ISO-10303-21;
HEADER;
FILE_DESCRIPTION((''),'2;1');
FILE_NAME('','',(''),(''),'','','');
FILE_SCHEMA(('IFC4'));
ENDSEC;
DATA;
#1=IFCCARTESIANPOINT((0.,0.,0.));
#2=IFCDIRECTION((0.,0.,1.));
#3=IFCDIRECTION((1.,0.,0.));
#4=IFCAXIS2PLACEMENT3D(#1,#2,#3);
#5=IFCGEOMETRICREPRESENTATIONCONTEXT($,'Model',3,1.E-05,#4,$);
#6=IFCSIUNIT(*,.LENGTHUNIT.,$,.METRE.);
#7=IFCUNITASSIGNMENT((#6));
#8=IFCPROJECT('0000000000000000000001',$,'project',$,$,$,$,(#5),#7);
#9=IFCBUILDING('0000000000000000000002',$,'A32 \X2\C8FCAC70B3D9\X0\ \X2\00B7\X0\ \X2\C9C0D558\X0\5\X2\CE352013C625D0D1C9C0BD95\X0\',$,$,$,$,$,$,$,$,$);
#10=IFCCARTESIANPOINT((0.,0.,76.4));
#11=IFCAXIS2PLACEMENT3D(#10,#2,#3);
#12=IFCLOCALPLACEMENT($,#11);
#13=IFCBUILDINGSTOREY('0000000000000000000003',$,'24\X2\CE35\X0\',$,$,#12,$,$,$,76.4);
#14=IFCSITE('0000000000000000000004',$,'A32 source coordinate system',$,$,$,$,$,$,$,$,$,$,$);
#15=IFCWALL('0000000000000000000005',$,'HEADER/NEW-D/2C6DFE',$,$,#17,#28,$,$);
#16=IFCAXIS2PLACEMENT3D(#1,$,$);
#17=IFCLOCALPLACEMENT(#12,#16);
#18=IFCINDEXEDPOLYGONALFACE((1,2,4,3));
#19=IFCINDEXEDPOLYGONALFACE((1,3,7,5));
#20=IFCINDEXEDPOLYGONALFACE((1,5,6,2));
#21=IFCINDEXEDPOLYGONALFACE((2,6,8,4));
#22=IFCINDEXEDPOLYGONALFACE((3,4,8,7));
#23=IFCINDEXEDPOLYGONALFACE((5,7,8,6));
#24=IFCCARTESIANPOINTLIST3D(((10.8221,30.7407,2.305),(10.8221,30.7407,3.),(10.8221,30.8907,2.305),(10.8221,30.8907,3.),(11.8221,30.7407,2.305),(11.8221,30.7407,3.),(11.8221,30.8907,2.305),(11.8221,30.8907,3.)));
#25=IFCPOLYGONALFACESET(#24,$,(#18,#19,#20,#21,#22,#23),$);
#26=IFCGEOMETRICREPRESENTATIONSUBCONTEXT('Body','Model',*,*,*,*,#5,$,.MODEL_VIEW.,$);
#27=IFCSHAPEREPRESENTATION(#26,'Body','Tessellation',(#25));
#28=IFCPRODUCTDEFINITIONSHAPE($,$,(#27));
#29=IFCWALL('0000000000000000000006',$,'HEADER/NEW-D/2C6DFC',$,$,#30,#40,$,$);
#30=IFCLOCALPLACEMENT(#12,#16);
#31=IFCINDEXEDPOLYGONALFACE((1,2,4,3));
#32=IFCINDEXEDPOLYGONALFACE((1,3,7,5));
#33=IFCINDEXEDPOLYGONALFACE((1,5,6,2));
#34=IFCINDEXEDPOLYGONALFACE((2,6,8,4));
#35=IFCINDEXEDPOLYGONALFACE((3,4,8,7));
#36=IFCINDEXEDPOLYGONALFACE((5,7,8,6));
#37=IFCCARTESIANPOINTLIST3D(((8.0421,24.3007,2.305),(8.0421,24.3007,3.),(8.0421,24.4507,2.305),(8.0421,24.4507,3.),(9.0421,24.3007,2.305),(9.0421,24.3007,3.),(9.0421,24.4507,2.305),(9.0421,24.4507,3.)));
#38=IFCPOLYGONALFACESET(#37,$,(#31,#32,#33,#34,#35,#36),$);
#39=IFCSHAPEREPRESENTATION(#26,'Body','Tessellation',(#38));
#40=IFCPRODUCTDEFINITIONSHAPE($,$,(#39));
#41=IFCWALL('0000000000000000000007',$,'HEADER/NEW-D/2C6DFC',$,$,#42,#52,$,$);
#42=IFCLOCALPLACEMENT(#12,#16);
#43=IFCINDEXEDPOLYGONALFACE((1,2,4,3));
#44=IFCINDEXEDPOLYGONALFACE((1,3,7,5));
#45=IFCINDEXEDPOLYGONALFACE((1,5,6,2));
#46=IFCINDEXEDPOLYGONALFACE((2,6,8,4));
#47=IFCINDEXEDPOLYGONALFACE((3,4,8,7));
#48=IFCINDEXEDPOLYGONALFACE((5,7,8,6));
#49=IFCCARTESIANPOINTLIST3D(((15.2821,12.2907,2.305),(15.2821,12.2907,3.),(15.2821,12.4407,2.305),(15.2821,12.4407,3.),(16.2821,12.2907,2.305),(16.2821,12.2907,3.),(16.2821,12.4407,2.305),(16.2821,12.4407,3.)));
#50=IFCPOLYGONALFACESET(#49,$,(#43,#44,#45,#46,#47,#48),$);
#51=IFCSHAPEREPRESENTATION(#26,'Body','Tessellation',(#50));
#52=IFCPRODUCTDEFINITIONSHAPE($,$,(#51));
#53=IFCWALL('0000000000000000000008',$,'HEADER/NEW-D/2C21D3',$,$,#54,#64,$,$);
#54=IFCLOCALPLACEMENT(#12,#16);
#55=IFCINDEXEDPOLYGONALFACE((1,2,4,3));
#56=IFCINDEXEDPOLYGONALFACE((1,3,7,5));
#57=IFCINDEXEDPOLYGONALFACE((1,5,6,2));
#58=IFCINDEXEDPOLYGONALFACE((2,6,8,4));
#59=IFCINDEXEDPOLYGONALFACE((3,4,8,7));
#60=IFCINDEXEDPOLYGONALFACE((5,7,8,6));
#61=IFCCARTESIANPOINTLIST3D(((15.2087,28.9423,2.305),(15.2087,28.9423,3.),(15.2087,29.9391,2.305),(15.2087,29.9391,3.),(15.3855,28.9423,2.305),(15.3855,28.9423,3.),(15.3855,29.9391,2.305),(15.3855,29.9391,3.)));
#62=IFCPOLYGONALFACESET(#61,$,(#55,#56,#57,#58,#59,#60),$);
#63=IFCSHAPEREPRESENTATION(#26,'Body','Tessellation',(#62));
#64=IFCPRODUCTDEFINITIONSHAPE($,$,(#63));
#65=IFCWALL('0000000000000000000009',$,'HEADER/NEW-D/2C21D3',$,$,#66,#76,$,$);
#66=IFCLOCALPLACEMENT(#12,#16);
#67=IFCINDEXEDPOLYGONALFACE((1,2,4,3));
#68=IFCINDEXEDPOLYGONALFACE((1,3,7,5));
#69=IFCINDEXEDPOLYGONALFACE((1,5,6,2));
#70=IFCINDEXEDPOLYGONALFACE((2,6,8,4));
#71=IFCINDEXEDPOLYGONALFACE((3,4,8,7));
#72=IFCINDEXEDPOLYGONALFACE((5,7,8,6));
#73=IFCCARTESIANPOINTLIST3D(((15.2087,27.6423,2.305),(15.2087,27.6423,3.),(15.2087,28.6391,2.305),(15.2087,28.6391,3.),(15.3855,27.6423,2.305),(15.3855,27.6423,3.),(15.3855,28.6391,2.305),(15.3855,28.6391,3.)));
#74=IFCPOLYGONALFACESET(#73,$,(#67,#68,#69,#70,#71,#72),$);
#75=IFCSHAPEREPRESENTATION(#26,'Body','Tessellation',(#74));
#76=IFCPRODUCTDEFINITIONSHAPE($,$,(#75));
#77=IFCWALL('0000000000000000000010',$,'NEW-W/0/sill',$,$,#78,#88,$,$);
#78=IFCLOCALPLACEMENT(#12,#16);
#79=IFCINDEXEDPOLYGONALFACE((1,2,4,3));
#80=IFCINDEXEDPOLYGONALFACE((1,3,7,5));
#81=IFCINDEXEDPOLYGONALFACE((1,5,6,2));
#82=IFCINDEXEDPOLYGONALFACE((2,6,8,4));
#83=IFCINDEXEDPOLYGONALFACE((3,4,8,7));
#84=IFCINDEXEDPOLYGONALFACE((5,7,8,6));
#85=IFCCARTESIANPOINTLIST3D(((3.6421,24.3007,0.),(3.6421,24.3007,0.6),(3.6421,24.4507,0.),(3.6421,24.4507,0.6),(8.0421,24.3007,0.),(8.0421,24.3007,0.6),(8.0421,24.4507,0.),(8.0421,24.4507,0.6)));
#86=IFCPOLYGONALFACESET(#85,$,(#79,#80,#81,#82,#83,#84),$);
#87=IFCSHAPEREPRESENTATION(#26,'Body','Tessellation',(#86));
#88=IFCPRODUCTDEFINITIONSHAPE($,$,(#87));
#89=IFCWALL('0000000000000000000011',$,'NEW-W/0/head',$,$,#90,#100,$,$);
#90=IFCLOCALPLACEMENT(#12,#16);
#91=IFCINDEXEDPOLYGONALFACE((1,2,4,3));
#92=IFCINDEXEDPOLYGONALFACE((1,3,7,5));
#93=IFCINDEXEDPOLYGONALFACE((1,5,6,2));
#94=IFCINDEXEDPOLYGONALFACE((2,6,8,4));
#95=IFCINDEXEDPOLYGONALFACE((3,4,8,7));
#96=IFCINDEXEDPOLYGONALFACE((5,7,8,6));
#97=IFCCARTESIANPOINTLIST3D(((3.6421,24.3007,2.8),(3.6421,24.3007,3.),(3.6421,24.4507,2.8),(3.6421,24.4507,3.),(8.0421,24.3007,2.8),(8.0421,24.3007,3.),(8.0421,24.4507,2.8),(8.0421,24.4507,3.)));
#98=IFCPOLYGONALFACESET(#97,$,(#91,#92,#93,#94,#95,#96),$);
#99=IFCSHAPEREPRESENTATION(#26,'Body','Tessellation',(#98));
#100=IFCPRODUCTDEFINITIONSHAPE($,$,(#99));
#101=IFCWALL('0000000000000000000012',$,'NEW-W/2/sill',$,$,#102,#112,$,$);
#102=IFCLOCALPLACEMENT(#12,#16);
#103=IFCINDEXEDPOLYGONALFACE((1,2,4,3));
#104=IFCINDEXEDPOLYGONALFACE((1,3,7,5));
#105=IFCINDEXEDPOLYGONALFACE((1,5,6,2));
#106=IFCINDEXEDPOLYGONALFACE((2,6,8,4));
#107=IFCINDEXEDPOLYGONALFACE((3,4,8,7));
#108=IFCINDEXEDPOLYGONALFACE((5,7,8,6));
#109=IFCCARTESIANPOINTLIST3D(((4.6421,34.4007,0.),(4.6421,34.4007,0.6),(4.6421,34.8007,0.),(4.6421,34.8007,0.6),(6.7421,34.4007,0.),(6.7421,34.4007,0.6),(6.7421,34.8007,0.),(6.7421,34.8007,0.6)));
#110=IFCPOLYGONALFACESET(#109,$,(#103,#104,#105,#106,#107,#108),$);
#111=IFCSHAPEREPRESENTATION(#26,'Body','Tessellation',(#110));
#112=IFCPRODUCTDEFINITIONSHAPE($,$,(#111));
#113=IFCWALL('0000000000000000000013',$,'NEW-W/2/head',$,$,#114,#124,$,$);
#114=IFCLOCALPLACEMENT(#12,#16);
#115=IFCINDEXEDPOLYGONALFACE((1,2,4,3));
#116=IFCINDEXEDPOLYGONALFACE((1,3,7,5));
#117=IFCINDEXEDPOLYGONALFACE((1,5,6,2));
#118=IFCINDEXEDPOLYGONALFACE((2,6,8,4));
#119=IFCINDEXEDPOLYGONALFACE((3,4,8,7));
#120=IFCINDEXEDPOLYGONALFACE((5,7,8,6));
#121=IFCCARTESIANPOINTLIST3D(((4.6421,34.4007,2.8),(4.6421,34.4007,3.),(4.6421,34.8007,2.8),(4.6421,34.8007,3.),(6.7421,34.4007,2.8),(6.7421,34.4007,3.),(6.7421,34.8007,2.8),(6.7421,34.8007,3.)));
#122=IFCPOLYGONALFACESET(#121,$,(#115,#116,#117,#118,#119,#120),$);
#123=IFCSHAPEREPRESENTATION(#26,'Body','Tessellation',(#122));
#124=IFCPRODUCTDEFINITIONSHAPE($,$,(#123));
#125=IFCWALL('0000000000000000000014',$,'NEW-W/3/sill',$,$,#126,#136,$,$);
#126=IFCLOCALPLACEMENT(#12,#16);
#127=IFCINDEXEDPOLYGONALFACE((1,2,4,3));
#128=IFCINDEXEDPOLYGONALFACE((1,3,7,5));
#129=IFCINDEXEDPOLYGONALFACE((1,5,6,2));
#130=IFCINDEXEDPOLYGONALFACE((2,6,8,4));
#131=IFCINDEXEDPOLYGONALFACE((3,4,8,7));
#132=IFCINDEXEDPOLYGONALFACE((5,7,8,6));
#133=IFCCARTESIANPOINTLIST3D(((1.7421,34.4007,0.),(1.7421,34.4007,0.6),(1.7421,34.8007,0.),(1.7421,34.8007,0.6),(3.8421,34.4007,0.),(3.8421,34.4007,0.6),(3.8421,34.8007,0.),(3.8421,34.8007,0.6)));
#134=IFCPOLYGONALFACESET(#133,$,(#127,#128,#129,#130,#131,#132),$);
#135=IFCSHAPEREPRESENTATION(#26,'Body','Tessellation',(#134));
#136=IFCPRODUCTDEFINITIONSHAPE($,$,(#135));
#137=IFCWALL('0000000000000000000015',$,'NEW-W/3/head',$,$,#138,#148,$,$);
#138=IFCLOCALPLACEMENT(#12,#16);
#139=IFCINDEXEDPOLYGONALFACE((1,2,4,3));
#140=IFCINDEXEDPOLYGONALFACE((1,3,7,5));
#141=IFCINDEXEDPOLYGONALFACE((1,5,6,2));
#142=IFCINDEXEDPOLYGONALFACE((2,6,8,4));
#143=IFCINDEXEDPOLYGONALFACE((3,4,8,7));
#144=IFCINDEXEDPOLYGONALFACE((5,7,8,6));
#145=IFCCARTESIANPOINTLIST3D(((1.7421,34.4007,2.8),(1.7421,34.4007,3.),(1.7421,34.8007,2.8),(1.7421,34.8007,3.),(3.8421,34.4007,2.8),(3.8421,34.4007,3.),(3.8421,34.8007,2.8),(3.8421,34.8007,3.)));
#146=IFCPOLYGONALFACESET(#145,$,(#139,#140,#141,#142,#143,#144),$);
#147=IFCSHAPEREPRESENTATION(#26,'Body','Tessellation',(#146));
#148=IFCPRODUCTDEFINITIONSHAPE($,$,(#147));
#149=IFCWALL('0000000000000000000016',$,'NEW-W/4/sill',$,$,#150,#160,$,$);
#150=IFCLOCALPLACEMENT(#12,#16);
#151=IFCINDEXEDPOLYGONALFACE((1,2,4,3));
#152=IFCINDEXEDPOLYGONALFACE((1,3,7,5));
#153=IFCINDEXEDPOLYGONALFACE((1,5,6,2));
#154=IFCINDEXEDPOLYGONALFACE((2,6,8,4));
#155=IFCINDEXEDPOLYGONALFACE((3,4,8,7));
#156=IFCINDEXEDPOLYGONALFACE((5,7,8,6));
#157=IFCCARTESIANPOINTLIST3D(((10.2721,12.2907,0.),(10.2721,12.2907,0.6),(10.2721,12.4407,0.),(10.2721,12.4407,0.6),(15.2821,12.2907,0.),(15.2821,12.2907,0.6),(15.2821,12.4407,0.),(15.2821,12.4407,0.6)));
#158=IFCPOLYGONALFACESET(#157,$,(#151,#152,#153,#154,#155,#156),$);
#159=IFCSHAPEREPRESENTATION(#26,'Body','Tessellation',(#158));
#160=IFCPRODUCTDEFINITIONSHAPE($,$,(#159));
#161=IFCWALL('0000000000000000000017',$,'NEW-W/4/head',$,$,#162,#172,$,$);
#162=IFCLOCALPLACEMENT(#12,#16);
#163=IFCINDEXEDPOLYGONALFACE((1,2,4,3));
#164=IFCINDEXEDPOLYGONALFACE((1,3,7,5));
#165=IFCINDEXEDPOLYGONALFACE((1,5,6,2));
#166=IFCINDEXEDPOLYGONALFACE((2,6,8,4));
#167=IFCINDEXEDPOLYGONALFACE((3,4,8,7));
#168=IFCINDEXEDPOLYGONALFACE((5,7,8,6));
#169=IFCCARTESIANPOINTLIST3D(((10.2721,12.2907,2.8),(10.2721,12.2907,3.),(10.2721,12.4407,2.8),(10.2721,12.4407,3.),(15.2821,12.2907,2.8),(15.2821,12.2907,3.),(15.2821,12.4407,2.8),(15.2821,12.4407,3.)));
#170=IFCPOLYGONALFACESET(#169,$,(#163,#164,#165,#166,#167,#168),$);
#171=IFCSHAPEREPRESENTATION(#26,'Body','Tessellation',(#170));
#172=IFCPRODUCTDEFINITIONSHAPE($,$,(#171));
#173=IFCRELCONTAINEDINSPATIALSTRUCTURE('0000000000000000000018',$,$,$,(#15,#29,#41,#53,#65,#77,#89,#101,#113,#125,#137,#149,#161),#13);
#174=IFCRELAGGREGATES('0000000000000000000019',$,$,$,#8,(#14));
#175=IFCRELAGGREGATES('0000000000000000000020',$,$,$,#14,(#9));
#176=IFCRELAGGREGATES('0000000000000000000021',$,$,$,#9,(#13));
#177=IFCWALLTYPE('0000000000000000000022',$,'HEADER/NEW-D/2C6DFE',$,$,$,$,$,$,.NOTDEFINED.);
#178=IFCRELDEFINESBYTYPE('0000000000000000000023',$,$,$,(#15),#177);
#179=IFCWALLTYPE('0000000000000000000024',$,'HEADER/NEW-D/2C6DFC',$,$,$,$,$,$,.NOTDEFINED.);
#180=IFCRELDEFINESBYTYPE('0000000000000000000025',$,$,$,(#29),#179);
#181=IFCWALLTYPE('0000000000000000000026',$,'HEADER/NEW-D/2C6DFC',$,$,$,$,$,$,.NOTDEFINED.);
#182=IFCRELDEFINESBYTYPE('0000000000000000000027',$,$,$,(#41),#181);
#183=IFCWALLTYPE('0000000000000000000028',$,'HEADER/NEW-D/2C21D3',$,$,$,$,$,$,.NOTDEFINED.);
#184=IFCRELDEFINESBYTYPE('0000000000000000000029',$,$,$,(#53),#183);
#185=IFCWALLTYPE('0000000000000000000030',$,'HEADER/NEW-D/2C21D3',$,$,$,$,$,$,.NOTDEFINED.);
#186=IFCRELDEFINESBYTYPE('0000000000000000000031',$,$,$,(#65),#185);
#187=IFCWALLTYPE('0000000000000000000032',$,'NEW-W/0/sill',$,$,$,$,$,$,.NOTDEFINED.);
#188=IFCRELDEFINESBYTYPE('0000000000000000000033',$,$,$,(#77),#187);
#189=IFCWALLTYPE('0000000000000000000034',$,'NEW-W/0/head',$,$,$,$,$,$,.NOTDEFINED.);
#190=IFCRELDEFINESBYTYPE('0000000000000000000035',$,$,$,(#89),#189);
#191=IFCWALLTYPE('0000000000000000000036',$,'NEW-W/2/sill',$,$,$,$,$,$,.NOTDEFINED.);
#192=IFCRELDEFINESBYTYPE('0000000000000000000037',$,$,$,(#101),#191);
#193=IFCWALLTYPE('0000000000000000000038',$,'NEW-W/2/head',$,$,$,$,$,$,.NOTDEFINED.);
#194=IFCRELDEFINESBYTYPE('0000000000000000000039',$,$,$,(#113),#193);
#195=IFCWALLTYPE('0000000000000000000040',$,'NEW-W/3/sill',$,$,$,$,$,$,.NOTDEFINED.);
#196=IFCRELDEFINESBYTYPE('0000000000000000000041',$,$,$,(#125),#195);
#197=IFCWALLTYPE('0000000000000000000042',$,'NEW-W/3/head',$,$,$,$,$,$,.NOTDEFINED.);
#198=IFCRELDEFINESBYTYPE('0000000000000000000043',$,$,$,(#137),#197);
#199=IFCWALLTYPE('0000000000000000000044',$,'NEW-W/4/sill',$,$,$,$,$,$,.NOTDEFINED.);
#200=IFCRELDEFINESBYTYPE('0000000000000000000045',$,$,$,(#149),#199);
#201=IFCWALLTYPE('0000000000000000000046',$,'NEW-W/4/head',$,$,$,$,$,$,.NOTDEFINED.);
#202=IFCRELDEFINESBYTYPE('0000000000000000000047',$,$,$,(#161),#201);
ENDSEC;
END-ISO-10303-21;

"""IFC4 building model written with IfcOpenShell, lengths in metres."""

from ifc_helpers import new_model, si_unit, frame, origin, origin_with_axes, place, context, subcontext, project, spatial, polyline, outline, extrude, source, transform, mapped, type_object, type_shapes, element, save


model = new_model("IFC4")

# Units and contexts
model_context = context("Model", 3, precision=1e-05, world=origin_with_axes())
body_context = subcontext(model_context, "Body", "Model", "MODEL_VIEW")
ifc_project = project(units=[si_unit("LENGTHUNIT", "METRE")], contexts=[model_context])

# Site, building, storey
site = spatial("IfcSite", under=ifc_project, Name="A32 source coordinate system")
building = spatial("IfcBuilding", under=site, Name="A32 주거동 · 지하5층–옥탑지붕")
storey_placement = place(None, frame((0.0, 0.0, 76.4), z_axis=(0.0, 0.0, 1.0), x_axis=(1.0, 0.0, 0.0)))
storey = spatial("IfcBuildingStorey", under=building, at=storey_placement, Name="24층", Elevation=76.4)

# Walls
wall_type_1 = type_object("IfcWallType", Name="HEADER/NEW-D/2C6DFE", PredefinedType="NOTDEFINED")
shared_shape_1 = source(origin(), body_context, "Body", "SweptSolid", [
    extrude(outline(polyline([(10.8221, 30.7407), (10.8221, 30.8907), (11.8221, 30.8907), (11.8221, 30.7407), (10.8221, 30.7407)])), frame((0.0, 0.0, 2.305)), (0.0, 0.0, 1.0), 0.695),
])
type_shapes(wall_type_1, [shared_shape_1])
wall_1_placement = place(storey_placement, origin_with_axes())
element("IfcWall", 1, at=wall_1_placement, inside=storey, type_object=wall_type_1, Name="HEADER/NEW-D/2C6DFE", context=body_context, shape_type="MappedRepresentation", body=[
    mapped(shared_shape_1, transform((0.0, 0.0, 0.0), scale=1.0)),
])
wall_type_2 = type_object("IfcWallType", Name="HEADER/NEW-D/2C6DFC", PredefinedType="NOTDEFINED")
shared_shape_2 = source(origin(), body_context, "Body", "SweptSolid", [
    extrude(outline(polyline([(8.0421, 24.3007), (8.0421, 24.4507), (9.0421, 24.4507), (9.0421, 24.3007), (8.0421, 24.3007)])), frame((0.0, 0.0, 2.305)), (0.0, 0.0, 1.0), 0.695),
])
type_shapes(wall_type_2, [shared_shape_2])
wall_2_placement = place(storey_placement, origin_with_axes())
element("IfcWall", 2, at=wall_2_placement, inside=storey, type_object=wall_type_2, Name="HEADER/NEW-D/2C6DFC", context=body_context, shape_type="MappedRepresentation", body=[
    mapped(shared_shape_2, transform((0.0, 0.0, 0.0), scale=1.0)),
])
wall_type_3 = type_object("IfcWallType", Name="HEADER/NEW-D/2C6DFC", PredefinedType="NOTDEFINED")
shared_shape_3 = source(origin(), body_context, "Body", "SweptSolid", [
    extrude(outline(polyline([(15.2821, 12.2907), (15.2821, 12.4407), (16.2821, 12.4407), (16.2821, 12.2907), (15.2821, 12.2907)])), frame((0.0, 0.0, 2.305)), (0.0, 0.0, 1.0), 0.695),
])
type_shapes(wall_type_3, [shared_shape_3])
wall_3_placement = place(storey_placement, origin_with_axes())
element("IfcWall", 3, at=wall_3_placement, inside=storey, type_object=wall_type_3, Name="HEADER/NEW-D/2C6DFC", context=body_context, shape_type="MappedRepresentation", body=[
    mapped(shared_shape_3, transform((0.0, 0.0, 0.0), scale=1.0)),
])
wall_type_4 = type_object("IfcWallType", Name="HEADER/NEW-D/2C21D3", PredefinedType="NOTDEFINED")
shared_shape_4 = source(origin(), body_context, "Body", "SweptSolid", [
    extrude(outline(polyline([(15.2087, 28.9423), (15.2087, 29.9391), (15.3855, 29.9391), (15.3855, 28.9423), (15.2087, 28.9423)])), frame((0.0, 0.0, 2.305)), (0.0, 0.0, 1.0), 0.695),
])
type_shapes(wall_type_4, [shared_shape_4])
wall_4_placement = place(storey_placement, origin_with_axes())
element("IfcWall", 4, at=wall_4_placement, inside=storey, type_object=wall_type_4, Name="HEADER/NEW-D/2C21D3", context=body_context, shape_type="MappedRepresentation", body=[
    mapped(shared_shape_4, transform((0.0, 0.0, 0.0), scale=1.0)),
])
wall_type_5 = type_object("IfcWallType", Name="HEADER/NEW-D/2C21D3", PredefinedType="NOTDEFINED")
shared_shape_5 = source(origin(), body_context, "Body", "SweptSolid", [
    extrude(outline(polyline([(15.2087, 27.6423), (15.2087, 28.6391), (15.3855, 28.6391), (15.3855, 27.6423), (15.2087, 27.6423)])), frame((0.0, 0.0, 2.305)), (0.0, 0.0, 1.0), 0.695),
])
type_shapes(wall_type_5, [shared_shape_5])
wall_5_placement = place(storey_placement, origin_with_axes())
element("IfcWall", 5, at=wall_5_placement, inside=storey, type_object=wall_type_5, Name="HEADER/NEW-D/2C21D3", context=body_context, shape_type="MappedRepresentation", body=[
    mapped(shared_shape_5, transform((0.0, 0.0, 0.0), scale=1.0)),
])
wall_type_6 = type_object("IfcWallType", Name="NEW-W/0/sill", PredefinedType="NOTDEFINED")
shared_shape_6 = source(origin(), body_context, "Body", "SweptSolid", [
    extrude(outline(polyline([(3.6421, 24.3007), (3.6421, 24.4507), (8.0421, 24.4507), (8.0421, 24.3007), (3.6421, 24.3007)])), origin(), (0.0, 0.0, 1.0), 0.6),
])
type_shapes(wall_type_6, [shared_shape_6])
wall_6_placement = place(storey_placement, origin_with_axes())
element("IfcWall", 6, at=wall_6_placement, inside=storey, type_object=wall_type_6, Name="NEW-W/0/sill", context=body_context, shape_type="MappedRepresentation", body=[
    mapped(shared_shape_6, transform((0.0, 0.0, 0.0), scale=1.0)),
])
wall_type_7 = type_object("IfcWallType", Name="NEW-W/0/head", PredefinedType="NOTDEFINED")
shared_shape_7 = source(origin(), body_context, "Body", "SweptSolid", [
    extrude(outline(polyline([(3.6421, 24.3007), (3.6421, 24.4507), (8.0421, 24.4507), (8.0421, 24.3007), (3.6421, 24.3007)])), frame((0.0, 0.0, 2.8)), (0.0, 0.0, 1.0), 0.2),
])
type_shapes(wall_type_7, [shared_shape_7])
wall_7_placement = place(storey_placement, origin_with_axes())
element("IfcWall", 7, at=wall_7_placement, inside=storey, type_object=wall_type_7, Name="NEW-W/0/head", context=body_context, shape_type="MappedRepresentation", body=[
    mapped(shared_shape_7, transform((0.0, 0.0, 0.0), scale=1.0)),
])
wall_type_8 = type_object("IfcWallType", Name="NEW-W/2/sill", PredefinedType="NOTDEFINED")
shared_shape_8 = source(origin(), body_context, "Body", "SweptSolid", [
    extrude(outline(polyline([(4.6421, 34.4007), (4.6421, 34.8007), (6.7421, 34.8007), (6.7421, 34.4007), (4.6421, 34.4007)])), origin(), (0.0, 0.0, 1.0), 0.6),
])
type_shapes(wall_type_8, [shared_shape_8])
wall_8_placement = place(storey_placement, origin_with_axes())
element("IfcWall", 8, at=wall_8_placement, inside=storey, type_object=wall_type_8, Name="NEW-W/2/sill", context=body_context, shape_type="MappedRepresentation", body=[
    mapped(shared_shape_8, transform((0.0, 0.0, 0.0), scale=1.0)),
])
wall_type_9 = type_object("IfcWallType", Name="NEW-W/2/head", PredefinedType="NOTDEFINED")
shared_shape_9 = source(origin(), body_context, "Body", "SweptSolid", [
    extrude(outline(polyline([(4.6421, 34.4007), (4.6421, 34.8007), (6.7421, 34.8007), (6.7421, 34.4007), (4.6421, 34.4007)])), frame((0.0, 0.0, 2.8)), (0.0, 0.0, 1.0), 0.2),
])
type_shapes(wall_type_9, [shared_shape_9])
wall_9_placement = place(storey_placement, origin_with_axes())
element("IfcWall", 9, at=wall_9_placement, inside=storey, type_object=wall_type_9, Name="NEW-W/2/head", context=body_context, shape_type="MappedRepresentation", body=[
    mapped(shared_shape_9, transform((0.0, 0.0, 0.0), scale=1.0)),
])
wall_type_10 = type_object("IfcWallType", Name="NEW-W/3/sill", PredefinedType="NOTDEFINED")
shared_shape_10 = source(origin(), body_context, "Body", "SweptSolid", [
    extrude(outline(polyline([(1.7421, 34.4007), (1.7421, 34.8007), (3.8421, 34.8007), (3.8421, 34.4007), (1.7421, 34.4007)])), origin(), (0.0, 0.0, 1.0), 0.6),
])
type_shapes(wall_type_10, [shared_shape_10])
wall_10_placement = place(storey_placement, origin_with_axes())
element("IfcWall", 10, at=wall_10_placement, inside=storey, type_object=wall_type_10, Name="NEW-W/3/sill", context=body_context, shape_type="MappedRepresentation", body=[
    mapped(shared_shape_10, transform((0.0, 0.0, 0.0), scale=1.0)),
])
wall_type_11 = type_object("IfcWallType", Name="NEW-W/3/head", PredefinedType="NOTDEFINED")
shared_shape_11 = source(origin(), body_context, "Body", "SweptSolid", [
    extrude(outline(polyline([(1.7421, 34.4007), (1.7421, 34.8007), (3.8421, 34.8007), (3.8421, 34.4007), (1.7421, 34.4007)])), frame((0.0, 0.0, 2.8)), (0.0, 0.0, 1.0), 0.2),
])
type_shapes(wall_type_11, [shared_shape_11])
wall_11_placement = place(storey_placement, origin_with_axes())
element("IfcWall", 11, at=wall_11_placement, inside=storey, type_object=wall_type_11, Name="NEW-W/3/head", context=body_context, shape_type="MappedRepresentation", body=[
    mapped(shared_shape_11, transform((0.0, 0.0, 0.0), scale=1.0)),
])
wall_type_12 = type_object("IfcWallType", Name="NEW-W/4/sill", PredefinedType="NOTDEFINED")
shared_shape_12 = source(origin(), body_context, "Body", "SweptSolid", [
    extrude(outline(polyline([(10.2721, 12.2907), (10.2721, 12.4407), (15.2821, 12.4407), (15.2821, 12.2907), (10.2721, 12.2907)])), origin(), (0.0, 0.0, 1.0), 0.6),
])
type_shapes(wall_type_12, [shared_shape_12])
wall_12_placement = place(storey_placement, origin_with_axes())
element("IfcWall", 12, at=wall_12_placement, inside=storey, type_object=wall_type_12, Name="NEW-W/4/sill", context=body_context, shape_type="MappedRepresentation", body=[
    mapped(shared_shape_12, transform((0.0, 0.0, 0.0), scale=1.0)),
])
wall_type_13 = type_object("IfcWallType", Name="NEW-W/4/head", PredefinedType="NOTDEFINED")
shared_shape_13 = source(origin(), body_context, "Body", "SweptSolid", [
    extrude(outline(polyline([(10.2721, 12.2907), (10.2721, 12.4407), (15.2821, 12.4407), (15.2821, 12.2907), (10.2721, 12.2907)])), frame((0.0, 0.0, 2.8)), (0.0, 0.0, 1.0), 0.2),
])
type_shapes(wall_type_13, [shared_shape_13])
wall_13_placement = place(storey_placement, origin_with_axes())
element("IfcWall", 13, at=wall_13_placement, inside=storey, type_object=wall_type_13, Name="NEW-W/4/head", context=body_context, shape_type="MappedRepresentation", body=[
    mapped(shared_shape_13, transform((0.0, 0.0, 0.0), scale=1.0)),
])

save(model, "model.ifc")
